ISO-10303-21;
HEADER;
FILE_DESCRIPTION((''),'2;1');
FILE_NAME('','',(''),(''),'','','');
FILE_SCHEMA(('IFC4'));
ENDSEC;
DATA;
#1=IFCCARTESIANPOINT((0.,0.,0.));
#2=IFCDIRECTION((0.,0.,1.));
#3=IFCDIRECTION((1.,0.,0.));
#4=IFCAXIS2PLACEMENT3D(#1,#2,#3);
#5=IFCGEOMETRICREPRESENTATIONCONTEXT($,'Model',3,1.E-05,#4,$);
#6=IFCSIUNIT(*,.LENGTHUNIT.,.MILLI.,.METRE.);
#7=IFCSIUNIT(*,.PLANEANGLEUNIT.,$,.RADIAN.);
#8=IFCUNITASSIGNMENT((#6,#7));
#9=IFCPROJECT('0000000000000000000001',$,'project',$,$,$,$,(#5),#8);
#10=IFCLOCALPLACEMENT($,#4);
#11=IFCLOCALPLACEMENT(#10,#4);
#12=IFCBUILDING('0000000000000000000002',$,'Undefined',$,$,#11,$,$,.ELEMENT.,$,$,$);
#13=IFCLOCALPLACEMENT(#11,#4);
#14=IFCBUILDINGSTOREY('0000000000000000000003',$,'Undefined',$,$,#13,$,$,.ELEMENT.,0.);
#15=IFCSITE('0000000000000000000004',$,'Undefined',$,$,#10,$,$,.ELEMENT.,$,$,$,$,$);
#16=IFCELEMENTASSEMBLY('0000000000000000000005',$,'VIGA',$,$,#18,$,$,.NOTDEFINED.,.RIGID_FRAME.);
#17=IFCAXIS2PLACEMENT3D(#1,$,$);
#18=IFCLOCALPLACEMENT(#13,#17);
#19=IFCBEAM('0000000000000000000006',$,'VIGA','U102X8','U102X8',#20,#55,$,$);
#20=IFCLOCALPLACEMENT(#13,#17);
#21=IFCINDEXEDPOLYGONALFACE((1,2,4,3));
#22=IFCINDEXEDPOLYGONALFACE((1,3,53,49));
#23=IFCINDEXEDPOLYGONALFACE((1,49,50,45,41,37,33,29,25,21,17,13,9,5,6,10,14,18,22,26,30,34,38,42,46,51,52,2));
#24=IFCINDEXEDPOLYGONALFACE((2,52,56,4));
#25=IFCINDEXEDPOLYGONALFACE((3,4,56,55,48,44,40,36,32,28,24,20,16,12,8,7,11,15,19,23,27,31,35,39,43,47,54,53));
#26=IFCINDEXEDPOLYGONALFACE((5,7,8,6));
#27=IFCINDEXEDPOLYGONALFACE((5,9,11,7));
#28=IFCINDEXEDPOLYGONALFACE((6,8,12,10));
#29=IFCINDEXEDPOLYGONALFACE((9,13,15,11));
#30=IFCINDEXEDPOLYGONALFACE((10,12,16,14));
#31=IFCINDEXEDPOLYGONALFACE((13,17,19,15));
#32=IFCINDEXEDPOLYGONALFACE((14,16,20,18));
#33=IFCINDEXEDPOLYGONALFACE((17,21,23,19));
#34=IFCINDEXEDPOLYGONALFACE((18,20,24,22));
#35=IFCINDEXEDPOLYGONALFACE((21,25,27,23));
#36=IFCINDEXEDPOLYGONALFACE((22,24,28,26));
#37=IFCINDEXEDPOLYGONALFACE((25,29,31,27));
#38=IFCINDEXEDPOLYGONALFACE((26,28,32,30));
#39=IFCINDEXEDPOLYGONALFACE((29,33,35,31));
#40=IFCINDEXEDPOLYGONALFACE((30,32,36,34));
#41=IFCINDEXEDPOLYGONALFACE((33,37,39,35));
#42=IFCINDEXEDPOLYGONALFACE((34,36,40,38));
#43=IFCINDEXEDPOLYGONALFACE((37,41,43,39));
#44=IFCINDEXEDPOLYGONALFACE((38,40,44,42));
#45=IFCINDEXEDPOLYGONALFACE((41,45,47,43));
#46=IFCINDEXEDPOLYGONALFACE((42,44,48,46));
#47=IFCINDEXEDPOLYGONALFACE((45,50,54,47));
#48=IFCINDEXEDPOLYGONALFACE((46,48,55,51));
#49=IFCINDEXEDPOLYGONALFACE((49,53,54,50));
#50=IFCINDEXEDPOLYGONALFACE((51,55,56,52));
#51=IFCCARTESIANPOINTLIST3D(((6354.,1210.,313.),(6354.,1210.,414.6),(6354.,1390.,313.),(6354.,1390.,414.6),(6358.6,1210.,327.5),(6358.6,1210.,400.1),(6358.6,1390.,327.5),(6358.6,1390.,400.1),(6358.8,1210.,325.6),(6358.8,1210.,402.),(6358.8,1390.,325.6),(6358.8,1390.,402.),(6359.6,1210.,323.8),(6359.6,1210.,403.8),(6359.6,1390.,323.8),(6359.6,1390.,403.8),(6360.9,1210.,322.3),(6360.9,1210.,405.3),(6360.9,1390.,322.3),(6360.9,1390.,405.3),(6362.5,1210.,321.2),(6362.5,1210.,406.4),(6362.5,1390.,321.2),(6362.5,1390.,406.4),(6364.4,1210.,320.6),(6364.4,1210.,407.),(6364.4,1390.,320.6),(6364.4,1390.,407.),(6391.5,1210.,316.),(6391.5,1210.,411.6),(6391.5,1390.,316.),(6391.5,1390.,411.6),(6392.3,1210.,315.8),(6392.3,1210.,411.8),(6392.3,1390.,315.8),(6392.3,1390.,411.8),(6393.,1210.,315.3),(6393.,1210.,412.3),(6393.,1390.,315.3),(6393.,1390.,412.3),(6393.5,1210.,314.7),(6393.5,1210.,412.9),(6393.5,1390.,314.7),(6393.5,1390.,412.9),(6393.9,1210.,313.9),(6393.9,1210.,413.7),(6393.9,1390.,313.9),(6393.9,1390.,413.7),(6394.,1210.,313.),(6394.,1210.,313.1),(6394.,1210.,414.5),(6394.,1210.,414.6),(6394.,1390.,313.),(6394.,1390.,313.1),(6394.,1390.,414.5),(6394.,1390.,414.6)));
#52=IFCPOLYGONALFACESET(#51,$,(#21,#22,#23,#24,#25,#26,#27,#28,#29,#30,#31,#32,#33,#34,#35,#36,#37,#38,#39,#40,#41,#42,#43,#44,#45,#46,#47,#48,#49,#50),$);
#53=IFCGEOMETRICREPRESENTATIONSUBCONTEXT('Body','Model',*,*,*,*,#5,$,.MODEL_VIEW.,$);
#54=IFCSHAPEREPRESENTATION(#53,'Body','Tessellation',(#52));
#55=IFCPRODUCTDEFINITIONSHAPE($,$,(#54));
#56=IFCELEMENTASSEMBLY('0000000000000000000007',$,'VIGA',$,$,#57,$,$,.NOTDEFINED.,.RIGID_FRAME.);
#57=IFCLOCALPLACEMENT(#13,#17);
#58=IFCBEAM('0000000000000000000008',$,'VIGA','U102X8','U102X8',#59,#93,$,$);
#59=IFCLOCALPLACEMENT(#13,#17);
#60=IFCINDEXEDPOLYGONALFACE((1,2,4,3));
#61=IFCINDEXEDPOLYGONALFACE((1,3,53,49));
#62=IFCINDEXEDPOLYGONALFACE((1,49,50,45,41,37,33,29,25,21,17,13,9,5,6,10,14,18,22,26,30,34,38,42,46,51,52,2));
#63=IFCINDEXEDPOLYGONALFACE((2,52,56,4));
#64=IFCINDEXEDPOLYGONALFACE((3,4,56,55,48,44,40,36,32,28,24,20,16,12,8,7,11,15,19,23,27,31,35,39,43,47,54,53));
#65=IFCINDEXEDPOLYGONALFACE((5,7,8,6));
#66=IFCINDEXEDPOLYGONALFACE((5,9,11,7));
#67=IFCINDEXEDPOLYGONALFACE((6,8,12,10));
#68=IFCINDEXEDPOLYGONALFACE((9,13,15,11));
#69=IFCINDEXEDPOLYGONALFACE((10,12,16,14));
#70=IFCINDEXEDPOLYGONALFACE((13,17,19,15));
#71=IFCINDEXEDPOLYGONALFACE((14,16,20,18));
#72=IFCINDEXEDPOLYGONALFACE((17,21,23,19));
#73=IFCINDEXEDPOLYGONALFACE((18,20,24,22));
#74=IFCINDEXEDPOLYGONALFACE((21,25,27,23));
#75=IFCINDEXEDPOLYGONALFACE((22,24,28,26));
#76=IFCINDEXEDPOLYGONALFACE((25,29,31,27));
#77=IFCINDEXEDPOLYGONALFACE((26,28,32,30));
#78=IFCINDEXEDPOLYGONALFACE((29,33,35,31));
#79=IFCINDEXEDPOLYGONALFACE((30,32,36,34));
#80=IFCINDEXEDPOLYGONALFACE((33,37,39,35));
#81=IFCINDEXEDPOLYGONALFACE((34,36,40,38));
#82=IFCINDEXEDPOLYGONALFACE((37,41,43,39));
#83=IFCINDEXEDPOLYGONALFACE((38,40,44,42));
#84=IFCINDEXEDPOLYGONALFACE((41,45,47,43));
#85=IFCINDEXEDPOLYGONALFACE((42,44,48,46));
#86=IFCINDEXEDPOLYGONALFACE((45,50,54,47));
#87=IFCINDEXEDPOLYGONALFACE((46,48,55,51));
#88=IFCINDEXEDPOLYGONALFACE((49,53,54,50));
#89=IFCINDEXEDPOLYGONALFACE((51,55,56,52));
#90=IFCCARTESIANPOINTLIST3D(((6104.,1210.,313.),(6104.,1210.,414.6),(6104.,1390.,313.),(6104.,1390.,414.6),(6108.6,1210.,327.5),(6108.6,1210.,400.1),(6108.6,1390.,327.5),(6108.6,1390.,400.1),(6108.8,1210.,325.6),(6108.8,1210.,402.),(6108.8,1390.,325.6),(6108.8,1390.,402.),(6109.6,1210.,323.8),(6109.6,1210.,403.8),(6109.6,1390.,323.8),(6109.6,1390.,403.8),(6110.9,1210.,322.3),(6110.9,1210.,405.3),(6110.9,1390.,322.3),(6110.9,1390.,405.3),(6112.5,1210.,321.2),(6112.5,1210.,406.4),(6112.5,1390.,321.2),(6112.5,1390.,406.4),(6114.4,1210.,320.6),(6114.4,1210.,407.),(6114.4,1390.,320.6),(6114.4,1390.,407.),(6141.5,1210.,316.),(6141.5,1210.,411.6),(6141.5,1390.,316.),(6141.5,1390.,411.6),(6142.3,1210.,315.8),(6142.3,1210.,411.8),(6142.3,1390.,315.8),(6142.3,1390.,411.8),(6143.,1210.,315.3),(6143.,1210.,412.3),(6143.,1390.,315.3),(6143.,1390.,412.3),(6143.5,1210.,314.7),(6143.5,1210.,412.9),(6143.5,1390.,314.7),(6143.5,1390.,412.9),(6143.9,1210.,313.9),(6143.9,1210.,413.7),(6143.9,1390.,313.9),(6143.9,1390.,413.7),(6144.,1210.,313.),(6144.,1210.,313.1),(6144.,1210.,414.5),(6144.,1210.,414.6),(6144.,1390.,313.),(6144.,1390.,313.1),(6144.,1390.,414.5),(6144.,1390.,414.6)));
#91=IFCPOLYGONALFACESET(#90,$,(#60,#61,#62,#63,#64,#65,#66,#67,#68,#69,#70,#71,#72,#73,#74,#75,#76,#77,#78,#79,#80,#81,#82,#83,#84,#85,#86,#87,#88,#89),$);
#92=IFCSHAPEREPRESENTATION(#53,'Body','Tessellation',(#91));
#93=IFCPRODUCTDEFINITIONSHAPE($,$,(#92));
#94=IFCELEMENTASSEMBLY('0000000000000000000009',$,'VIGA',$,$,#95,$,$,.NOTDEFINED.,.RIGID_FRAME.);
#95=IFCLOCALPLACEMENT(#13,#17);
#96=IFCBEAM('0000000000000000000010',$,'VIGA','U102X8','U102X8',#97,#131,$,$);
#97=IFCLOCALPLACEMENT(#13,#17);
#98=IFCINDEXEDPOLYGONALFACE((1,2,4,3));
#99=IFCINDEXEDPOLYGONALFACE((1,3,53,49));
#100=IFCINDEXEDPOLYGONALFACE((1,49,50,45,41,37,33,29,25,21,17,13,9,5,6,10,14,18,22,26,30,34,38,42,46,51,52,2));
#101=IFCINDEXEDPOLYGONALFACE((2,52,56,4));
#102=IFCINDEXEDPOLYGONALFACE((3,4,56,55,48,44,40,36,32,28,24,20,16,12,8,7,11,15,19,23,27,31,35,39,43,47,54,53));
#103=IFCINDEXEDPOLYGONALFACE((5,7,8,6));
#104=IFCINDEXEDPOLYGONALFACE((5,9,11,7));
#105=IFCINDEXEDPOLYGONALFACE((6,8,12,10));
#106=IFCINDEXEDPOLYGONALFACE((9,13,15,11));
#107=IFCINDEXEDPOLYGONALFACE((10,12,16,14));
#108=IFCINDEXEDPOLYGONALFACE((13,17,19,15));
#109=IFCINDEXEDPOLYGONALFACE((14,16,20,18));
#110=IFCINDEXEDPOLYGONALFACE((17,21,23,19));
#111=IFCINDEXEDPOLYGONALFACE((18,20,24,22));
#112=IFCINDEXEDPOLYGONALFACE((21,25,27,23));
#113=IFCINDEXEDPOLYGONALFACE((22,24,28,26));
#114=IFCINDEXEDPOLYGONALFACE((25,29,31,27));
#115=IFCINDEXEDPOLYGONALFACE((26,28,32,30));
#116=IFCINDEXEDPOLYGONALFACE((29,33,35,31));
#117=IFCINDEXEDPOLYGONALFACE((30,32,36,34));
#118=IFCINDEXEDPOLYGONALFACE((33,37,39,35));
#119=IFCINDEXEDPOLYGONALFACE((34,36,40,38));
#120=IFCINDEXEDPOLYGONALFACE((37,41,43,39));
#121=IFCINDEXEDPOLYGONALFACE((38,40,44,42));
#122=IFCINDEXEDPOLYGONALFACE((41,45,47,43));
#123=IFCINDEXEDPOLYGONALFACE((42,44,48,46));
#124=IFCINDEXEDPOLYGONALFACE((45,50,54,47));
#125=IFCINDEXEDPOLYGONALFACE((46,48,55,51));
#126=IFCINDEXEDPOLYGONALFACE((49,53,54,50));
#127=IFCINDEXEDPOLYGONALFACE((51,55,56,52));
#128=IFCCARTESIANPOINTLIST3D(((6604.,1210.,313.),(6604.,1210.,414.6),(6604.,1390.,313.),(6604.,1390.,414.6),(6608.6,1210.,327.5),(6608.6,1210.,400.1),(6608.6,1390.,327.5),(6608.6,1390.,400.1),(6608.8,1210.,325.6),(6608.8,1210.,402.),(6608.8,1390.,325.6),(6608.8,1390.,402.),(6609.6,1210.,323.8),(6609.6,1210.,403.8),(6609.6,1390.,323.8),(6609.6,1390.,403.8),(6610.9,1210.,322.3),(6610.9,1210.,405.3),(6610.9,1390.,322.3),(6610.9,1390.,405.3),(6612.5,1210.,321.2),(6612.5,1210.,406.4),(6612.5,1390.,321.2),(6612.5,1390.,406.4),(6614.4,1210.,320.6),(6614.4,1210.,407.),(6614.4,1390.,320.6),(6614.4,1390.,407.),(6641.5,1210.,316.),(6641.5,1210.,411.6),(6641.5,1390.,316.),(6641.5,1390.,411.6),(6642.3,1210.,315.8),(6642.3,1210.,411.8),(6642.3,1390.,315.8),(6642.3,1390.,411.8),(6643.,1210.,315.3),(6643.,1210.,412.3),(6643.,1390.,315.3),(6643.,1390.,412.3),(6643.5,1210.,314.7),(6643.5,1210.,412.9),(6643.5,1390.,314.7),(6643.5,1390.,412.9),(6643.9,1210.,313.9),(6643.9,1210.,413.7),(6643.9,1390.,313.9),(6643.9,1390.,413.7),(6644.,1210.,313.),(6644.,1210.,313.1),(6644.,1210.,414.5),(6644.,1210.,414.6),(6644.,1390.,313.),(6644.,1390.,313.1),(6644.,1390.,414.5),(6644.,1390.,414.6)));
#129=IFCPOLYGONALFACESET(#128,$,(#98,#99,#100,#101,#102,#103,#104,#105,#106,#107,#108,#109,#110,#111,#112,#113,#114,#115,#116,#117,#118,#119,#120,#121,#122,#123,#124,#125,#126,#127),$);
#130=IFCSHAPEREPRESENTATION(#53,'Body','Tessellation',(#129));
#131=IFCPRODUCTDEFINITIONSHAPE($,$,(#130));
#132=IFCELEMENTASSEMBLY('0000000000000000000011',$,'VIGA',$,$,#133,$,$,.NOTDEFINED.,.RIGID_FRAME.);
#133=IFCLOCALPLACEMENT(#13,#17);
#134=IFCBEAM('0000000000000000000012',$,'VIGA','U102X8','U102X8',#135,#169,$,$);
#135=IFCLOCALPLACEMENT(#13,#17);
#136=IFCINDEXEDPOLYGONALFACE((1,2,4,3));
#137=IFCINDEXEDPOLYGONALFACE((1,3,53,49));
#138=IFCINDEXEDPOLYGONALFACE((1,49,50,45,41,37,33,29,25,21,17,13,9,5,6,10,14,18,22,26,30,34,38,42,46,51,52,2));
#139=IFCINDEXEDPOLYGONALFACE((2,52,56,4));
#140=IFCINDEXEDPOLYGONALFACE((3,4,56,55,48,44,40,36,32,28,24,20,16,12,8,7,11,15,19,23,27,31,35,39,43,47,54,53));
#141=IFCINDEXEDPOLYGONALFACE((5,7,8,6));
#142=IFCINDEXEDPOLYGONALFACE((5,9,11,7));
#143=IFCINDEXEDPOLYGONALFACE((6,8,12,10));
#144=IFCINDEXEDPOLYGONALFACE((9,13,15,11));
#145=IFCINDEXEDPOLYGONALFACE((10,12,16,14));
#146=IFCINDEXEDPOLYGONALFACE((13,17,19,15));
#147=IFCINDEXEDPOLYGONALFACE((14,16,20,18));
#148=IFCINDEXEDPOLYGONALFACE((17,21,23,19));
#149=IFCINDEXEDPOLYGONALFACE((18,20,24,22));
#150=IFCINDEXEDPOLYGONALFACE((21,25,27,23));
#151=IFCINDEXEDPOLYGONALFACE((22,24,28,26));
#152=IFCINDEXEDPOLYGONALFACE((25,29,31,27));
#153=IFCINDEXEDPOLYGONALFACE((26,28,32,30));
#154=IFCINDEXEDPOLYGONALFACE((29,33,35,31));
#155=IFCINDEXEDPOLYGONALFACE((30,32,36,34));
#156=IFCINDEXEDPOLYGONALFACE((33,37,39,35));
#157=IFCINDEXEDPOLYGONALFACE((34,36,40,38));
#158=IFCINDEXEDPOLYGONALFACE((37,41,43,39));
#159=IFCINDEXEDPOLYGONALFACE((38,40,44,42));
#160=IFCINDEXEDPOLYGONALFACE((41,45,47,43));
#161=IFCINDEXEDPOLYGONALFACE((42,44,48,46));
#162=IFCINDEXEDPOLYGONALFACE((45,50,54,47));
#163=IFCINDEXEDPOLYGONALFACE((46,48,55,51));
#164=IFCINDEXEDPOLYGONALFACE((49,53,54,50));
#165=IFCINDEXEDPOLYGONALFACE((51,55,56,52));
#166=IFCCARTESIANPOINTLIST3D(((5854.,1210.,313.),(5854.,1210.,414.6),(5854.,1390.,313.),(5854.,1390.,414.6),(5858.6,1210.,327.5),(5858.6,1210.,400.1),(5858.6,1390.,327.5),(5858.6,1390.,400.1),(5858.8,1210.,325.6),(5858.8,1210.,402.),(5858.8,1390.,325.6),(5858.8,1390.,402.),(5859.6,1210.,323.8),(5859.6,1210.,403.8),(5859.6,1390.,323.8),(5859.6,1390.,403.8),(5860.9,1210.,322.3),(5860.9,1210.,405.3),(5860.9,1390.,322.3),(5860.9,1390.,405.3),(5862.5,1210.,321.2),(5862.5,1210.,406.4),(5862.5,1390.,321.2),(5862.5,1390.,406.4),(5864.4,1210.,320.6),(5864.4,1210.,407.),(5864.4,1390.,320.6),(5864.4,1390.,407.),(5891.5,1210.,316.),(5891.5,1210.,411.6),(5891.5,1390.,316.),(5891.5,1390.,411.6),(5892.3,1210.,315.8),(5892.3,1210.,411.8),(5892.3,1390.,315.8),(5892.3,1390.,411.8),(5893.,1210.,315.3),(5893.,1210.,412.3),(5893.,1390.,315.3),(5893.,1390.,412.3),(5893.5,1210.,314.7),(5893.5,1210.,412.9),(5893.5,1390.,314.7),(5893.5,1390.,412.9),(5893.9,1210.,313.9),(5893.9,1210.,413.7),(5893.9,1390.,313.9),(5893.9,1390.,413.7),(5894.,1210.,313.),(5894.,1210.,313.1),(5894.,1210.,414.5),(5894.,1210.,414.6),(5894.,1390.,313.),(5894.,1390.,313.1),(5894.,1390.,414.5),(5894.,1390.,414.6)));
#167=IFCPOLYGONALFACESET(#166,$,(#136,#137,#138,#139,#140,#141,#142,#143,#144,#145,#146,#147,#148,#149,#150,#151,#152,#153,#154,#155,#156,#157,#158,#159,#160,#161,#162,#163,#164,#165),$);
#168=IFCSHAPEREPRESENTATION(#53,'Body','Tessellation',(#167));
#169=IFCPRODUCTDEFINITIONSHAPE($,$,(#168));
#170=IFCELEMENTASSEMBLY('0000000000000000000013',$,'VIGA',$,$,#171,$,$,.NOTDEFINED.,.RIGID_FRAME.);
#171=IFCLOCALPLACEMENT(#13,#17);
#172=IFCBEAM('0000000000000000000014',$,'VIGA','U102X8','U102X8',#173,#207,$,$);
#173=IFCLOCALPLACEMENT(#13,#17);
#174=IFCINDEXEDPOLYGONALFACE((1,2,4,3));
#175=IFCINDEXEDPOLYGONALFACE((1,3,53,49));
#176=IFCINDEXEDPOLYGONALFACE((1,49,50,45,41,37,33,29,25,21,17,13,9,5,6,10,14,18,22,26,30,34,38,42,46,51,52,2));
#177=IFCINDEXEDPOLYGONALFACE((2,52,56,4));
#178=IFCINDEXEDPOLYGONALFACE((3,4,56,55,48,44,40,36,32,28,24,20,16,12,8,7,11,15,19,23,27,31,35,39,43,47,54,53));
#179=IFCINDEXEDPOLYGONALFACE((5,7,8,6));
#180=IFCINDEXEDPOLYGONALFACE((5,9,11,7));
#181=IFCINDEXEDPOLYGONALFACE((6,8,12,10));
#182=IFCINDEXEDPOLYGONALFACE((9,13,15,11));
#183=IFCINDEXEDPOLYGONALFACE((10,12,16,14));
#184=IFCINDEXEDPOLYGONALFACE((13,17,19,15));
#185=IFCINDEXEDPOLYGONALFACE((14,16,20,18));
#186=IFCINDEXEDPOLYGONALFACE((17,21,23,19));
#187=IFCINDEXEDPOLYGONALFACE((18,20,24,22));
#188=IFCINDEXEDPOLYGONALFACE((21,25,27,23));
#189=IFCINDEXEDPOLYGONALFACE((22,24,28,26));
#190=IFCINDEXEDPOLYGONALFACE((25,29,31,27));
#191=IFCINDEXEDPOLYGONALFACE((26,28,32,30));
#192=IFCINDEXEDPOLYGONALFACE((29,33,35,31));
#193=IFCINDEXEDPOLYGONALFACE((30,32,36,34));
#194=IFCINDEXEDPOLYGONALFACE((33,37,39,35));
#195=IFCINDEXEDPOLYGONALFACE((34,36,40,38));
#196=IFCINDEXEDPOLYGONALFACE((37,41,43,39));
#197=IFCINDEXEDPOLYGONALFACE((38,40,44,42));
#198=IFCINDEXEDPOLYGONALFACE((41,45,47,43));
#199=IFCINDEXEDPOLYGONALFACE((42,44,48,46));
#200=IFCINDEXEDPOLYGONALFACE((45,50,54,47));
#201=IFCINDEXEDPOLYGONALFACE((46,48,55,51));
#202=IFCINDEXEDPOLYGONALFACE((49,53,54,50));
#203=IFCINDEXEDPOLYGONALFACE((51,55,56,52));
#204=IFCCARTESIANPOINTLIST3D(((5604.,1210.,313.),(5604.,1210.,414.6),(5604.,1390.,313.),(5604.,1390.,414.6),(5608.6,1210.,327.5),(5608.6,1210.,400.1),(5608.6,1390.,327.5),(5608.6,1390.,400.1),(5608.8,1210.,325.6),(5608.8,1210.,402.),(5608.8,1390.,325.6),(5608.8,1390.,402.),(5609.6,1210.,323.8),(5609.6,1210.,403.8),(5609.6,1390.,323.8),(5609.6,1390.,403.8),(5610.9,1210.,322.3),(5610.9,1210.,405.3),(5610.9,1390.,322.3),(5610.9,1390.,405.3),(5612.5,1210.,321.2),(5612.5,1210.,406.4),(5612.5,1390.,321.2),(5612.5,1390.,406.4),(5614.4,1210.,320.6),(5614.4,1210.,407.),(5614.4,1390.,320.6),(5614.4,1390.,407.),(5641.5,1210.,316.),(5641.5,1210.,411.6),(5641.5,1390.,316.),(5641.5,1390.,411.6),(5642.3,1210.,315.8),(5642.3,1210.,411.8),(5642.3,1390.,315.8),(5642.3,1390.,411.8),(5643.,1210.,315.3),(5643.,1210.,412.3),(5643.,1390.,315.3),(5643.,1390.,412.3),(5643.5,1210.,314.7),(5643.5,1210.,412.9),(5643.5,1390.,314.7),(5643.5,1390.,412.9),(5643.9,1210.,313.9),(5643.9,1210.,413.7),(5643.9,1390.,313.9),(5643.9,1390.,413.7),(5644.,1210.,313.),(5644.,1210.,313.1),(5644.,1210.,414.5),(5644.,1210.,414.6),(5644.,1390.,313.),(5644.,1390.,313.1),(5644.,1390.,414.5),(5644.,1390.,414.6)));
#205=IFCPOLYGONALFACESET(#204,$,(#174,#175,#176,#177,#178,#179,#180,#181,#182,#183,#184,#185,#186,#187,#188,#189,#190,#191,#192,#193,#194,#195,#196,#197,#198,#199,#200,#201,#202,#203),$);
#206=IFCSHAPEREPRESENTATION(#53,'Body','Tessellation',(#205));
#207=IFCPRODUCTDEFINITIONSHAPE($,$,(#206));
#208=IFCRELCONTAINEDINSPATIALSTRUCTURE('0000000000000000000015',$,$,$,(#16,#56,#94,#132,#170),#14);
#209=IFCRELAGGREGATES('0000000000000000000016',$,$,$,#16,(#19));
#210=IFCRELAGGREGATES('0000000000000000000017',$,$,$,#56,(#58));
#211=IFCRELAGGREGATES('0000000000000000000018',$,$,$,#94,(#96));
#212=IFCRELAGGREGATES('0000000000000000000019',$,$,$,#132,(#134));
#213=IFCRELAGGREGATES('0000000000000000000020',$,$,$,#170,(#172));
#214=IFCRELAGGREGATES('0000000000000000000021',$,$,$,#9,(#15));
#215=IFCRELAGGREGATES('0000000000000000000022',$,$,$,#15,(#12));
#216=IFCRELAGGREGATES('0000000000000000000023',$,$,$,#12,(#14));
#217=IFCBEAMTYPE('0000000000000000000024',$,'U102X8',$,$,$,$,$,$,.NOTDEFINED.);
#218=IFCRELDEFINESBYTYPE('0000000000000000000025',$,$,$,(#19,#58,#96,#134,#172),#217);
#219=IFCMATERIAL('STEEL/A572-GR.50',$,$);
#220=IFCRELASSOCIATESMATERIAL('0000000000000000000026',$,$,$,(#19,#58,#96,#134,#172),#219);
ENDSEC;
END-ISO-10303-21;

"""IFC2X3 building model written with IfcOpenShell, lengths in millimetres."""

from ifc_helpers import new_model, si_unit, frame, origin_with_axes, origin_2d_with_axis, place, context, subcontext, project, spatial, u_section, extrude, material, type_object, element, aggregate, save


model = new_model("IFC2X3")

# Units and contexts
model_context = context("Model", 3, precision=1e-05, world=origin_with_axes())
body_context = subcontext(model_context, "Body", "Model", "MODEL_VIEW")
ifc_project = project(units=[si_unit("LENGTHUNIT", "METRE", prefix="MILLI"), si_unit("PLANEANGLEUNIT", "RADIAN")], contexts=[model_context])

# Site, building, storey
site_placement = place(None, origin_with_axes())
site = spatial("IfcSite", under=ifc_project, at=site_placement, Name="Undefined", CompositionType="ELEMENT")
building_placement = place(site_placement, origin_with_axes())
building = spatial("IfcBuilding", under=site, at=building_placement, Name="Undefined", CompositionType="ELEMENT")
storey_placement = place(building_placement, origin_with_axes())
storey = spatial("IfcBuildingStorey", under=building, at=storey_placement, Name="Undefined", CompositionType="ELEMENT", Elevation=0.0)

# Element assemblies, beams
assembly_1_placement = place(storey_placement, origin_with_axes())
assembly_1 = element("IfcElementAssembly", 1, at=assembly_1_placement, inside=storey, Name="VIGA", AssemblyPlace="NOTDEFINED", PredefinedType="RIGID_FRAME")
ifc_material = material(Name="STEEL/A572-GR.50")
beam_type = type_object("IfcBeamType", Name="U102X8", PredefinedType="NOTDEFINED")
beam_1_placement = place(assembly_1_placement, frame((6374.0, 1210.0, 363.8), z_axis=(0.0, 0.0, 1.0), x_axis=(0.0, 1.0, 0.0)))
beam_1 = element("IfcBeam", 2, at=beam_1_placement, type_object=beam_type, material=ifc_material, Name="VIGA", Description="U102X8", ObjectType="U102X8", context=body_context, shape_type="SweptSolid", body=[
    extrude(u_section(Depth=101.6, FlangeWidth=40.0, WebThickness=4.6, FlangeThickness=6.0, FilletRadius=7.0, EdgeRadius=3.0, FlangeSlope=0.16839, at=origin_2d_with_axis()), frame((180.0, 0.0, 0.0), z_axis=(-1.0, 0.0, 0.0), x_axis=(0.0, -1.0, 0.0)), (0.0, 0.0, 1.0), 180.0),
])
aggregate(assembly_1, [beam_1])
assembly_2_placement = place(storey_placement, origin_with_axes())
assembly_2 = element("IfcElementAssembly", 3, at=assembly_2_placement, inside=storey, Name="VIGA", AssemblyPlace="NOTDEFINED", PredefinedType="RIGID_FRAME")
beam_2_placement = place(assembly_2_placement, frame((6124.0, 1210.0, 363.8), z_axis=(0.0, 0.0, 1.0), x_axis=(0.0, 1.0, 0.0)))
beam_2 = element("IfcBeam", 4, at=beam_2_placement, type_object=beam_type, material=ifc_material, Name="VIGA", Description="U102X8", ObjectType="U102X8", context=body_context, shape_type="SweptSolid", body=[
    extrude(u_section(Depth=101.6, FlangeWidth=40.0, WebThickness=4.6, FlangeThickness=6.0, FilletRadius=7.0, EdgeRadius=3.0, FlangeSlope=0.16839, at=origin_2d_with_axis()), frame((180.0, 0.0, 0.0), z_axis=(-1.0, 0.0, 0.0), x_axis=(0.0, -1.0, 0.0)), (0.0, 0.0, 1.0), 180.0),
])
aggregate(assembly_2, [beam_2])
assembly_3_placement = place(storey_placement, origin_with_axes())
assembly_3 = element("IfcElementAssembly", 5, at=assembly_3_placement, inside=storey, Name="VIGA", AssemblyPlace="NOTDEFINED", PredefinedType="RIGID_FRAME")
beam_3_placement = place(assembly_3_placement, frame((6624.0, 1210.0, 363.8), z_axis=(0.0, 0.0, 1.0), x_axis=(0.0, 1.0, 0.0)))
beam_3 = element("IfcBeam", 6, at=beam_3_placement, type_object=beam_type, material=ifc_material, Name="VIGA", Description="U102X8", ObjectType="U102X8", context=body_context, shape_type="SweptSolid", body=[
    extrude(u_section(Depth=101.6, FlangeWidth=40.0, WebThickness=4.6, FlangeThickness=6.0, FilletRadius=7.0, EdgeRadius=3.0, FlangeSlope=0.16839, at=origin_2d_with_axis()), frame((180.0, 0.0, 0.0), z_axis=(-1.0, 0.0, 0.0), x_axis=(0.0, -1.0, 0.0)), (0.0, 0.0, 1.0), 180.0),
])
aggregate(assembly_3, [beam_3])
assembly_4_placement = place(storey_placement, origin_with_axes())
assembly_4 = element("IfcElementAssembly", 7, at=assembly_4_placement, inside=storey, Name="VIGA", AssemblyPlace="NOTDEFINED", PredefinedType="RIGID_FRAME")
beam_4_placement = place(assembly_4_placement, frame((5874.0, 1210.0, 363.8), z_axis=(0.0, 0.0, 1.0), x_axis=(0.0, 1.0, 0.0)))
beam_4 = element("IfcBeam", 8, at=beam_4_placement, type_object=beam_type, material=ifc_material, Name="VIGA", Description="U102X8", ObjectType="U102X8", context=body_context, shape_type="SweptSolid", body=[
    extrude(u_section(Depth=101.6, FlangeWidth=40.0, WebThickness=4.6, FlangeThickness=6.0, FilletRadius=7.0, EdgeRadius=3.0, FlangeSlope=0.16839, at=origin_2d_with_axis()), frame((180.0, 0.0, 0.0), z_axis=(-1.0, 0.0, 0.0), x_axis=(0.0, -1.0, 0.0)), (0.0, 0.0, 1.0), 180.0),
])
aggregate(assembly_4, [beam_4])
assembly_5_placement = place(storey_placement, origin_with_axes())
assembly_5 = element("IfcElementAssembly", 9, at=assembly_5_placement, inside=storey, Name="VIGA", AssemblyPlace="NOTDEFINED", PredefinedType="RIGID_FRAME")
beam_5_placement = place(assembly_5_placement, frame((5624.0, 1210.0, 363.8), z_axis=(0.0, 0.0, 1.0), x_axis=(0.0, 1.0, 0.0)))
beam_5 = element("IfcBeam", 10, at=beam_5_placement, type_object=beam_type, material=ifc_material, Name="VIGA", Description="U102X8", ObjectType="U102X8", context=body_context, shape_type="SweptSolid", body=[
    extrude(u_section(Depth=101.6, FlangeWidth=40.0, WebThickness=4.6, FlangeThickness=6.0, FilletRadius=7.0, EdgeRadius=3.0, FlangeSlope=0.16839, at=origin_2d_with_axis()), frame((180.0, 0.0, 0.0), z_axis=(-1.0, 0.0, 0.0), x_axis=(0.0, -1.0, 0.0)), (0.0, 0.0, 1.0), 180.0),
])
aggregate(assembly_5, [beam_5])

save(model, "model.ifc")
